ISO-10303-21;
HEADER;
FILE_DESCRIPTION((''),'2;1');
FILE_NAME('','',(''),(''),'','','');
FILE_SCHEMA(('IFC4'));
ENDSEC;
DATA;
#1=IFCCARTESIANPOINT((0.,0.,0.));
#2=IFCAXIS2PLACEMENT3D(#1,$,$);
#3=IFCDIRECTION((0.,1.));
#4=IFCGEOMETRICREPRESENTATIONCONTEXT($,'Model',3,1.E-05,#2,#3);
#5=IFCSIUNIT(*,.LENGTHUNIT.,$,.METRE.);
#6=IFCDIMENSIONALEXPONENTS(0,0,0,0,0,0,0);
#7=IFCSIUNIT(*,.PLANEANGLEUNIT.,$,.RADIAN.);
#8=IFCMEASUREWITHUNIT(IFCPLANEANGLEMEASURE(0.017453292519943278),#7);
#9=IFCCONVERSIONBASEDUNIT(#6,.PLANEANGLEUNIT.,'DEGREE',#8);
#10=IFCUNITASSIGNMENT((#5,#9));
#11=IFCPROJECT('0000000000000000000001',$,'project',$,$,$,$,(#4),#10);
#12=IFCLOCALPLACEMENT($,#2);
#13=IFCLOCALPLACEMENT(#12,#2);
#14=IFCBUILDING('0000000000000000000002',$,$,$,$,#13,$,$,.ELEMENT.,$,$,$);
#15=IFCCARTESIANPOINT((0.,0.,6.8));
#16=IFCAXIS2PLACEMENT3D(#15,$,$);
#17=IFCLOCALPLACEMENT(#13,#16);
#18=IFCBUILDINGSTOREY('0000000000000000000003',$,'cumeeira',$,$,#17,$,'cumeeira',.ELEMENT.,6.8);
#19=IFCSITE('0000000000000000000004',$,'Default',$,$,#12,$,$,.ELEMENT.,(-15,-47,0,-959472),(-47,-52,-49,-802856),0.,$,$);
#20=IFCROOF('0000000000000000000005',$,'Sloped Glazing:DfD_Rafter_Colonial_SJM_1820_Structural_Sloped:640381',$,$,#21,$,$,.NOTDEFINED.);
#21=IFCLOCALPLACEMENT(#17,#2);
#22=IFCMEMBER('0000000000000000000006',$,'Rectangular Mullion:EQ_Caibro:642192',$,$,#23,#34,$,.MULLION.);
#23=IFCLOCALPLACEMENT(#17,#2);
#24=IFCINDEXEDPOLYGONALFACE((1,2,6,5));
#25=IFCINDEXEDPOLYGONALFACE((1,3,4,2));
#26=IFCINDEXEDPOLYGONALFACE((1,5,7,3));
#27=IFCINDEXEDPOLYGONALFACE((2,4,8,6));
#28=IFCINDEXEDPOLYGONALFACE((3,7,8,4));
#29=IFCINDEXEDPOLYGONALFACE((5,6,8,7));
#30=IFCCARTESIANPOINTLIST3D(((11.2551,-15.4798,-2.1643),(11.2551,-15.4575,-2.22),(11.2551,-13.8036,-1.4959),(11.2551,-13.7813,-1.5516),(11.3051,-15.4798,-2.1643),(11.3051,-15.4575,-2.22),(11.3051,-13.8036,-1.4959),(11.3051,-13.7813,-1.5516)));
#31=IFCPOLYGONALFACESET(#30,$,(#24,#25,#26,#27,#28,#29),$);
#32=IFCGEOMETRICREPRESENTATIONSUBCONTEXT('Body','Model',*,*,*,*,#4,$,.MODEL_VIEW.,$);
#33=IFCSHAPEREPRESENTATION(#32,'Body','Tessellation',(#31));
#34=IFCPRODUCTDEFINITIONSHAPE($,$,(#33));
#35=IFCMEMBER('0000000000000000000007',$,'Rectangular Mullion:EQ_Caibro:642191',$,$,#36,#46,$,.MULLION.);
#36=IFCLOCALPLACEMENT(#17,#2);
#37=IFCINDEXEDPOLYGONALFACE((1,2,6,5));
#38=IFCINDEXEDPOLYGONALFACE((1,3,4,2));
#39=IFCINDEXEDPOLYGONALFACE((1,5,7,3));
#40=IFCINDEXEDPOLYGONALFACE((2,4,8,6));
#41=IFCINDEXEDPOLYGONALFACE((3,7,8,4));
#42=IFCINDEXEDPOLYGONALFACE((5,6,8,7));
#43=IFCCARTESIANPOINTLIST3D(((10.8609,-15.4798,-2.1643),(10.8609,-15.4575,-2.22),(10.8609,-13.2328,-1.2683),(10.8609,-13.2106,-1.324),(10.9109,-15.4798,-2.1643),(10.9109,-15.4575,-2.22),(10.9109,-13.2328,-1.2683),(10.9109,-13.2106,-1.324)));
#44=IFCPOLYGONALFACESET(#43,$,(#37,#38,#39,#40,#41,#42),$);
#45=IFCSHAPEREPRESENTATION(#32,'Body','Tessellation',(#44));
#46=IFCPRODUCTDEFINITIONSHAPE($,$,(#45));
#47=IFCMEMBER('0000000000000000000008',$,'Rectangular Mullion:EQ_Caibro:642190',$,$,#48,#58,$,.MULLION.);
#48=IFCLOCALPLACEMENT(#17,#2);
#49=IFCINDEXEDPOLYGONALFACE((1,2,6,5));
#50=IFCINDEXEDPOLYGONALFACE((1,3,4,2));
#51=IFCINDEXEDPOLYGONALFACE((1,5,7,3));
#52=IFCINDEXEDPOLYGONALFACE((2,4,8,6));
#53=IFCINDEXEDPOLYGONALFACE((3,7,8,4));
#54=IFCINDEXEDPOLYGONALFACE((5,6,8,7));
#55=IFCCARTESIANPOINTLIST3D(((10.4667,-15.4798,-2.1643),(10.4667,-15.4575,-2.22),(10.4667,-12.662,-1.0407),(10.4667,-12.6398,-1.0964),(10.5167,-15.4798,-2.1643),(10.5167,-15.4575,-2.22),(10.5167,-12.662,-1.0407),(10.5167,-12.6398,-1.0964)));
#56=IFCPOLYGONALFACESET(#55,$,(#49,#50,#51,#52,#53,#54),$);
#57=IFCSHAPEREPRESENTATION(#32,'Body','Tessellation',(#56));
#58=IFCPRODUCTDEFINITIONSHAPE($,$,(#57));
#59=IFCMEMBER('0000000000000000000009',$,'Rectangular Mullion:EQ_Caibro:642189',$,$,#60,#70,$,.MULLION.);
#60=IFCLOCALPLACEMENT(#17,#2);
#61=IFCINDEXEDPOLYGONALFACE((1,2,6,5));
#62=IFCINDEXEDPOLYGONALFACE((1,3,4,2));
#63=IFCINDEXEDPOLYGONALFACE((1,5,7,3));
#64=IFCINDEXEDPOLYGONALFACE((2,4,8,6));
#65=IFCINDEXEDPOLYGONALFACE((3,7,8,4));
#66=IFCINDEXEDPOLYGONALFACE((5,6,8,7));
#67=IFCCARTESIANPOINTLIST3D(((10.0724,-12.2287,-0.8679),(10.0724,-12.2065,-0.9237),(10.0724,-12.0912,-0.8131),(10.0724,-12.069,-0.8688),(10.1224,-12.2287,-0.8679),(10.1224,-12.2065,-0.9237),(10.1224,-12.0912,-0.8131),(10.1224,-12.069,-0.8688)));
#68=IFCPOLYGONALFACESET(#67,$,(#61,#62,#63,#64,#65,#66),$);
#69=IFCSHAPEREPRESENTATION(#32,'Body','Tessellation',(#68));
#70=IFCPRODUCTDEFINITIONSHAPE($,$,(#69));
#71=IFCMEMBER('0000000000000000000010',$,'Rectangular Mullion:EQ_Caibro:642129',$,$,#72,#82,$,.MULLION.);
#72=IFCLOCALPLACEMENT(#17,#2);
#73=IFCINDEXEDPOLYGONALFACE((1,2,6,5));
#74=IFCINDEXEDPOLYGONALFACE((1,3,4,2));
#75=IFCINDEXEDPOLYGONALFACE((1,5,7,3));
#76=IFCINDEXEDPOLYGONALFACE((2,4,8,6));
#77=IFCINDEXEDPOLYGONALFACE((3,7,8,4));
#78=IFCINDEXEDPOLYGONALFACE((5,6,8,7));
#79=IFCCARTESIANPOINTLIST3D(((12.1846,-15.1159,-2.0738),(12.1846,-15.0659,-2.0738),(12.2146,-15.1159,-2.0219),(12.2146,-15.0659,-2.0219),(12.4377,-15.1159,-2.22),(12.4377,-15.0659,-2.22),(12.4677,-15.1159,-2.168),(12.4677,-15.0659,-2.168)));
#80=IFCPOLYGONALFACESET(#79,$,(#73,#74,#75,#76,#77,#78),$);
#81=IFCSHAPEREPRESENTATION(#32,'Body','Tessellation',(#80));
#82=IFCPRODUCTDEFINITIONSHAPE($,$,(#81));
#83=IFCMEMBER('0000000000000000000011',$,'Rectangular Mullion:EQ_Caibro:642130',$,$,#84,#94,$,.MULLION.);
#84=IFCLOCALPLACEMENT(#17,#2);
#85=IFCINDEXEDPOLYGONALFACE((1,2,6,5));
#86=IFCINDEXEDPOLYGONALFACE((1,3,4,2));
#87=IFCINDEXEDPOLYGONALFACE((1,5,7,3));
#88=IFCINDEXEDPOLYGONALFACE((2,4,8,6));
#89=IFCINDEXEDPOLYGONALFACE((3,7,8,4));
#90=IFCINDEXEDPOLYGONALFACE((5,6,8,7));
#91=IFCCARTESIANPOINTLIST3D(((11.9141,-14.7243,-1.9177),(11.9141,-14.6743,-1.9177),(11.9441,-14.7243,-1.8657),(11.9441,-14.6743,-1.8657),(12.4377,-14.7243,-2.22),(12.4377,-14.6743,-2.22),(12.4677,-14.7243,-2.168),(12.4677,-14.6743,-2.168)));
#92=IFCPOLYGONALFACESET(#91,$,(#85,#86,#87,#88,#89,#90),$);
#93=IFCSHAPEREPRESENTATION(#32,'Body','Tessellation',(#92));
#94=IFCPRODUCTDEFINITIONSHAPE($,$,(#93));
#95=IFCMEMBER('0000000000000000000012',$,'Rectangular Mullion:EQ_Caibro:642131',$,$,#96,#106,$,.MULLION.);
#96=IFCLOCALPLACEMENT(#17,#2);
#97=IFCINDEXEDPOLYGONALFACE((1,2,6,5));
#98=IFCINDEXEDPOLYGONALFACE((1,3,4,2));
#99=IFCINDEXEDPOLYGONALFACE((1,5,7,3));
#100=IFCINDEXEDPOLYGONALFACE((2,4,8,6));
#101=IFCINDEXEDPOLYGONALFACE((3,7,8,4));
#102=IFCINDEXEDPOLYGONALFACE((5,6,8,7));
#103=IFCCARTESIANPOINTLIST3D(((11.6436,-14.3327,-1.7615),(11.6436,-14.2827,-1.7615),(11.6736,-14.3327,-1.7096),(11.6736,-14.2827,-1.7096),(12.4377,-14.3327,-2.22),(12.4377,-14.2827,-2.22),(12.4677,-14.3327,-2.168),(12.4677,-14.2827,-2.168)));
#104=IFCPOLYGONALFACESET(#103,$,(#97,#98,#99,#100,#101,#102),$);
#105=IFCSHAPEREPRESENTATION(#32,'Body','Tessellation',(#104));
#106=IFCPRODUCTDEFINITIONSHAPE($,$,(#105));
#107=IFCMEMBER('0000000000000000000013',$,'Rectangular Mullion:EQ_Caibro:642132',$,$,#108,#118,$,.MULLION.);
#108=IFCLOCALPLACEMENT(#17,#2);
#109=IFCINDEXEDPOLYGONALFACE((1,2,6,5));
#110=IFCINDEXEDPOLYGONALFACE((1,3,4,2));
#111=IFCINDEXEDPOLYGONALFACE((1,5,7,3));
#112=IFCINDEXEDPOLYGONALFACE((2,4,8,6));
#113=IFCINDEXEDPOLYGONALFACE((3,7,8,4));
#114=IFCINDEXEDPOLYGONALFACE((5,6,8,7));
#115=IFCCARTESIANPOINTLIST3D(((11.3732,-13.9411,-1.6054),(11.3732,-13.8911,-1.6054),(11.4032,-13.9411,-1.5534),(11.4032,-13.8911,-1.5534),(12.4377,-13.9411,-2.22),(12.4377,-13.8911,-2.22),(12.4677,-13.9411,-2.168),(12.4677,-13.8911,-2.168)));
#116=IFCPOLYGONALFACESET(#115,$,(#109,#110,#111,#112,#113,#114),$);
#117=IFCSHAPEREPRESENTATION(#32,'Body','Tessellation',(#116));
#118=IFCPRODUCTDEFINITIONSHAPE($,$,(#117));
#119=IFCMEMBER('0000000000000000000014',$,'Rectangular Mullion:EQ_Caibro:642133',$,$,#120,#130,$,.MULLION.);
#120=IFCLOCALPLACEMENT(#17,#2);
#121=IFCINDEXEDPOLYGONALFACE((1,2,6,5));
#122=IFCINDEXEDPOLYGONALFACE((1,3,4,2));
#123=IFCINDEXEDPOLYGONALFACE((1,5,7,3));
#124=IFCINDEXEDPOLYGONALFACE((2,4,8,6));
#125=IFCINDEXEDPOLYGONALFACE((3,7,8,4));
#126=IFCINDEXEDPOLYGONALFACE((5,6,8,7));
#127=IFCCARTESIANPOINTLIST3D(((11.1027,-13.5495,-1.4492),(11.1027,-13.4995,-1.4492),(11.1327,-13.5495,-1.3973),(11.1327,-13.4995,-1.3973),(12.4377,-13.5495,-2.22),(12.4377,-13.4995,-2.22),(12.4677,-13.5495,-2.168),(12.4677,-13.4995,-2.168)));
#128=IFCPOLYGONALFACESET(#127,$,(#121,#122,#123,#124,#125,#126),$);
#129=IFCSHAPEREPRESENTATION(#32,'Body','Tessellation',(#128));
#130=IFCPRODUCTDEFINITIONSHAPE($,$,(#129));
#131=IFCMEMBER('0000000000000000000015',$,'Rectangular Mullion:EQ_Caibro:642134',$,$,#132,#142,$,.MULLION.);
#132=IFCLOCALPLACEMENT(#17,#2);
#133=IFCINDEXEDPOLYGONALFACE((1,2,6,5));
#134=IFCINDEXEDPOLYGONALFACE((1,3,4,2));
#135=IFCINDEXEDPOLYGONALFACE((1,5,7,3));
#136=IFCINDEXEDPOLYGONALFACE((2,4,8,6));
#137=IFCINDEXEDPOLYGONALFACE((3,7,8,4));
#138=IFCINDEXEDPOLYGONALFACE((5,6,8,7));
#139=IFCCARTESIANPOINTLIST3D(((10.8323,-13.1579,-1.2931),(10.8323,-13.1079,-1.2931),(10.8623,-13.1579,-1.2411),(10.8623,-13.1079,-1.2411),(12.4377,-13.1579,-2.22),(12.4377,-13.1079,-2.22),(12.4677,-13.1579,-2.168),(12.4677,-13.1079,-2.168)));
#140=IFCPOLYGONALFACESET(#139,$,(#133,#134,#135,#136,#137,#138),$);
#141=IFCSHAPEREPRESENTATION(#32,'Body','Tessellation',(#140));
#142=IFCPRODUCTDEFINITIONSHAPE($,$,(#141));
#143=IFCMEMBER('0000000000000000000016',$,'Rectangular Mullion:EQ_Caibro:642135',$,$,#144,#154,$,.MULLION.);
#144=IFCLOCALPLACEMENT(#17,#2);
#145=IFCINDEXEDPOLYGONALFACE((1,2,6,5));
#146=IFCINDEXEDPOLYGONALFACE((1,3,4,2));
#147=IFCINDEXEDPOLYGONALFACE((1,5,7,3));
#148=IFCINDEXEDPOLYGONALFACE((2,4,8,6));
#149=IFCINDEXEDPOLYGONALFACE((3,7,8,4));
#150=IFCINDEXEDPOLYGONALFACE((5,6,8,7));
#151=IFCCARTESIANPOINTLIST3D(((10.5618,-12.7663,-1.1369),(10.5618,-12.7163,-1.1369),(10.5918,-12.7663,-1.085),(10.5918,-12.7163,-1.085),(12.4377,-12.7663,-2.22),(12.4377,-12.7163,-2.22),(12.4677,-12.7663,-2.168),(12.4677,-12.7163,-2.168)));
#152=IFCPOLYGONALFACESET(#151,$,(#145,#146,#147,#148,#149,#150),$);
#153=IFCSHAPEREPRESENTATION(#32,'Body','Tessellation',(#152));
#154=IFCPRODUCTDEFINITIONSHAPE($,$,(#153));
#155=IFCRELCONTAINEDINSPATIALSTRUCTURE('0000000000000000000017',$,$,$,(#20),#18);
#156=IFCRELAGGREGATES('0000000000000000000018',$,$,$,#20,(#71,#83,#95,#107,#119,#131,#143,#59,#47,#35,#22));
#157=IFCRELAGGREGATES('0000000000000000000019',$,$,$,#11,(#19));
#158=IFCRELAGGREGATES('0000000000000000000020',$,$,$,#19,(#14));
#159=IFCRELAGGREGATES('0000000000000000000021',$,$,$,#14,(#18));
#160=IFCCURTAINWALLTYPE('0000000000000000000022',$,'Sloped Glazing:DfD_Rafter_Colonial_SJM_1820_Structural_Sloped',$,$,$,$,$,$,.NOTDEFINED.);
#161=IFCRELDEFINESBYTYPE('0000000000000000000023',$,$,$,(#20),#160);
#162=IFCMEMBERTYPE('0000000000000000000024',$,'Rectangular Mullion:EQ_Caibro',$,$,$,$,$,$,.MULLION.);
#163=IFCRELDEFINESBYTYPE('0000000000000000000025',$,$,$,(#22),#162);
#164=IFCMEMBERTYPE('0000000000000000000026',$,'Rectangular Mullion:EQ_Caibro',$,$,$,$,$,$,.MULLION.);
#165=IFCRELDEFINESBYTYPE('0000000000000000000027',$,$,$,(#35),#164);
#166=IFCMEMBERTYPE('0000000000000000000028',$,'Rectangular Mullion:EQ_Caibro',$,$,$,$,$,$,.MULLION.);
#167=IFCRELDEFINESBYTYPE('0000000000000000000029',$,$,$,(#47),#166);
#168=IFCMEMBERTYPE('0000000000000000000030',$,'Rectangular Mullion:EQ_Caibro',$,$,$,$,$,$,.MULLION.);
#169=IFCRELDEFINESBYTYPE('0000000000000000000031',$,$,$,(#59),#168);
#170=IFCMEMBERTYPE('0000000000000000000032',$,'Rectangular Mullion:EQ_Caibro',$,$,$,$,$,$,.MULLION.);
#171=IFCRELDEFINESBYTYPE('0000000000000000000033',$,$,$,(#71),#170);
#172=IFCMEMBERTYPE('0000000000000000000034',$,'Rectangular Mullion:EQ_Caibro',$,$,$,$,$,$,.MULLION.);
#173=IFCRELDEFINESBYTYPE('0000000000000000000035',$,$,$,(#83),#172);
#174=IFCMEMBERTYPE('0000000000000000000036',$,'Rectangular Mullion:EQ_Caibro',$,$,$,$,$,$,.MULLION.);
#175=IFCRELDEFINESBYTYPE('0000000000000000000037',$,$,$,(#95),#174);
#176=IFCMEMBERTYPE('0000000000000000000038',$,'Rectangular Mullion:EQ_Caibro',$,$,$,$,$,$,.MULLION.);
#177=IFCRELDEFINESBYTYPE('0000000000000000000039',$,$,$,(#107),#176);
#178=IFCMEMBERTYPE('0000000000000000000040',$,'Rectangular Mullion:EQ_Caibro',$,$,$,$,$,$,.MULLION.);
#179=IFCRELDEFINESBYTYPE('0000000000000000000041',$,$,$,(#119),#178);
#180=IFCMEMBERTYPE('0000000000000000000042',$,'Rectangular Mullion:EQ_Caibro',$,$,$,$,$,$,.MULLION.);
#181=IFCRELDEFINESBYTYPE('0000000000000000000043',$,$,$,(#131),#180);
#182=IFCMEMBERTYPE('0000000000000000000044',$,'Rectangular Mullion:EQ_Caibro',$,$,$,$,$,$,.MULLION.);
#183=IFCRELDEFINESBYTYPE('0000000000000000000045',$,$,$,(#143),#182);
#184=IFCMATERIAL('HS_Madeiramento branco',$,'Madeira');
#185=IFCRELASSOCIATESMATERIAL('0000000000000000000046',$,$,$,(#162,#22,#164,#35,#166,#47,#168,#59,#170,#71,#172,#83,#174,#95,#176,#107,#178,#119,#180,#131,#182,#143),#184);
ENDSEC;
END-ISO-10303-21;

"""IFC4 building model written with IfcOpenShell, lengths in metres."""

from ifc_helpers import new_model, entity, si_unit, converted_unit, direction, frame, origin, place, context, subcontext, project, spatial, indexed_curve, outline, extrude, source, transform, mapped, material, type_object, type_shapes, element, aggregate, save


model = new_model("IFC4")

# Units and contexts
model_context = context("Model", 3, precision=1e-05, world=origin(), true_north=direction((0.0, 1.0)))
body_context = subcontext(model_context, "Body", "Model", "MODEL_VIEW")
ifc_project = project(units=[si_unit("LENGTHUNIT", "METRE"), converted_unit("PLANEANGLEUNIT", "DEGREE", entity("IfcPlaneAngleMeasure", 0.017453292519943278), si_unit("PLANEANGLEUNIT", "RADIAN"), dimensions=[0, 0, 0, 0, 0, 0, 0])], contexts=[model_context])

# Site, building, storey
site_placement = place(None, origin())
site = spatial("IfcSite", under=ifc_project, at=site_placement, Name="Default", CompositionType="ELEMENT", RefLatitude=(-15, -47, 0, -959472), RefLongitude=(-47, -52, -49, -802856), RefElevation=0.0)
building_placement = place(site_placement, origin())
building = spatial("IfcBuilding", under=site, at=building_placement, CompositionType="ELEMENT")
storey_placement = place(building_placement, frame((0.0, 0.0, 6.8)))
storey = spatial("IfcBuildingStorey", under=building, at=storey_placement, Name="cumeeira", LongName="cumeeira", CompositionType="ELEMENT", Elevation=6.8)

# Roof
curtain_wall_type_1 = type_object("IfcCurtainWallType", Name="Sloped Glazing:DfD_Rafter_Colonial_SJM_1820_Structural_Sloped", PredefinedType="NOTDEFINED")
roof_1_placement = place(storey_placement, frame((0.0, 0.0, -6.8)))
roof_1 = element("IfcRoof", 1, at=roof_1_placement, inside=storey, type_object=curtain_wall_type_1, Name="Sloped Glazing:DfD_Rafter_Colonial_SJM_1820_Structural_Sloped:640381", PredefinedType="NOTDEFINED")
ifc_material_1 = material(Name="HS_Madeiramento branco", Category="Madeira")

# Members
member_type_1 = type_object("IfcMemberType", Name="Rectangular Mullion:EQ_Caibro", PredefinedType="MULLION", material=ifc_material_1)
shared_shape_1 = source(origin(), body_context, "Body", "SweptSolid", [
    extrude(outline(indexed_curve([(-0.025, -0.03), (0.025, -0.03), (0.025, 0.03), (-0.025, 0.03), (-0.025, -0.03)], self_intersect=False)), frame((0.0, -0.03, -1.8045), z_axis=(0.0, 0.0, 1.0), x_axis=(-1.0, 0.0, 0.0)), (0.0, 0.0, 1.0), 1.8045),
])
type_shapes(member_type_1, [shared_shape_1])
member_1_placement = place(roof_1_placement, frame((11.2801, -13.7813, 5.2484), z_axis=(0.0, 0.928878, 0.370385), x_axis=(1.0, 0.0, 0.0)))
member_1 = element("IfcMember", 2, at=member_1_placement, type_object=member_type_1, material=ifc_material_1, Name="Rectangular Mullion:EQ_Caibro:642192", PredefinedType="MULLION", context=body_context, shape_type="MappedRepresentation", body=[
    mapped(shared_shape_1, transform((0.0, 0.0, 0.0), scale=1.0)),
])
member_type_2 = type_object("IfcMemberType", Name="Rectangular Mullion:EQ_Caibro", PredefinedType="MULLION", material=ifc_material_1)
shared_shape_2 = source(origin(), body_context, "Body", "SweptSolid", [
    extrude(outline(indexed_curve([(-0.025, -0.03), (0.025, -0.03), (0.025, 0.03), (-0.025, 0.03), (-0.025, -0.03)], self_intersect=False)), frame((0.0, -0.03, -2.419), z_axis=(0.0, 0.0, 1.0), x_axis=(-1.0, 0.0, 0.0)), (0.0, 0.0, 1.0), 2.419),
])
type_shapes(member_type_2, [shared_shape_2])
member_2_placement = place(roof_1_placement, frame((10.8859, -13.2106, 5.476), z_axis=(0.0, 0.928878, 0.370385), x_axis=(1.0, 0.0, 0.0)))
member_2 = element("IfcMember", 3, at=member_2_placement, type_object=member_type_2, material=ifc_material_1, Name="Rectangular Mullion:EQ_Caibro:642191", PredefinedType="MULLION", context=body_context, shape_type="MappedRepresentation", body=[
    mapped(shared_shape_2, transform((0.0, 0.0, 0.0), scale=1.0)),
])
member_type_3 = type_object("IfcMemberType", Name="Rectangular Mullion:EQ_Caibro", PredefinedType="MULLION", material=ifc_material_1)
shared_shape_3 = source(origin(), body_context, "Body", "SweptSolid", [
    extrude(outline(indexed_curve([(-0.025, -0.03), (0.025, -0.03), (0.025, 0.03), (-0.025, 0.03), (-0.025, -0.03)], self_intersect=False)), frame((0.0, -0.03, -3.0335), z_axis=(0.0, 0.0, 1.0), x_axis=(-1.0, 0.0, 0.0)), (0.0, 0.0, 1.0), 3.0335),
])
type_shapes(member_type_3, [shared_shape_3])
member_3_placement = place(roof_1_placement, frame((10.4917, -12.6398, 5.7036), z_axis=(0.0, 0.928878, 0.370385), x_axis=(1.0, 0.0, 0.0)))
member_3 = element("IfcMember", 4, at=member_3_placement, type_object=member_type_3, material=ifc_material_1, Name="Rectangular Mullion:EQ_Caibro:642190", PredefinedType="MULLION", context=body_context, shape_type="MappedRepresentation", body=[
    mapped(shared_shape_3, transform((0.0, 0.0, 0.0), scale=1.0)),
])
member_type_4 = type_object("IfcMemberType", Name="Rectangular Mullion:EQ_Caibro", PredefinedType="MULLION", material=ifc_material_1)
shared_shape_4 = source(origin(), body_context, "Body", "SweptSolid", [
    extrude(outline(indexed_curve([(-0.025, -0.03), (0.025, -0.03), (0.025, 0.03), (-0.025, 0.03), (-0.025, -0.03)], self_intersect=False)), frame((0.0, -0.03, -0.148), z_axis=(0.0, 0.0, 1.0), x_axis=(-1.0, 0.0, 0.0)), (0.0, 0.0, 1.0), 0.148),
])
type_shapes(member_type_4, [shared_shape_4])
member_4_placement = place(roof_1_placement, frame((10.0974, -12.069, 5.9312), z_axis=(0.0, 0.928878, 0.370385), x_axis=(1.0, 0.0, 0.0)))
member_4 = element("IfcMember", 5, at=member_4_placement, type_object=member_type_4, material=ifc_material_1, Name="Rectangular Mullion:EQ_Caibro:642189", PredefinedType="MULLION", context=body_context, shape_type="MappedRepresentation", body=[
    mapped(shared_shape_4, transform((0.0, 0.0, 0.0), scale=1.0)),
])
member_type_5 = type_object("IfcMemberType", Name="Rectangular Mullion:EQ_Caibro", PredefinedType="MULLION", material=ifc_material_1)
shared_shape_5 = source(origin(), body_context, "Body", "SweptSolid", [
    extrude(outline(indexed_curve([(-0.025, -0.03), (0.025, -0.03), (0.025, 0.03), (-0.025, 0.03), (-0.025, -0.03)], self_intersect=False)), frame((0.0, -0.03, -0.2924), z_axis=(0.0, 0.0, 1.0), x_axis=(-1.0, 0.0, 0.0)), (0.0, 0.0, 1.0), 0.2924),
])
type_shapes(member_type_5, [shared_shape_5])
member_5_placement = place(roof_1_placement, frame((12.1846, -15.0909, 4.7262), z_axis=(-0.866025, 0.0, 0.5), x_axis=(0.0, 1.0, 0.0)))
member_5 = element("IfcMember", 6, at=member_5_placement, type_object=member_type_5, material=ifc_material_1, Name="Rectangular Mullion:EQ_Caibro:642129", PredefinedType="MULLION", context=body_context, shape_type="MappedRepresentation", body=[
    mapped(shared_shape_5, transform((0.0, 0.0, 0.0), scale=1.0)),
])
member_type_6 = type_object("IfcMemberType", Name="Rectangular Mullion:EQ_Caibro", PredefinedType="MULLION", material=ifc_material_1)
shared_shape_6 = source(origin(), body_context, "Body", "SweptSolid", [
    extrude(outline(indexed_curve([(-0.025, -0.03), (0.025, -0.03), (0.025, 0.03), (-0.025, 0.03), (-0.025, -0.03)], self_intersect=False)), frame((0.0, -0.03, -0.6047), z_axis=(0.0, 0.0, 1.0), x_axis=(-1.0, 0.0, 0.0)), (0.0, 0.0, 1.0), 0.6047),
])
type_shapes(member_type_6, [shared_shape_6])
member_6_placement = place(roof_1_placement, frame((11.9141, -14.6993, 4.8823), z_axis=(-0.866025, 0.0, 0.5), x_axis=(0.0, 1.0, 0.0)))
member_6 = element("IfcMember", 7, at=member_6_placement, type_object=member_type_6, material=ifc_material_1, Name="Rectangular Mullion:EQ_Caibro:642130", PredefinedType="MULLION", context=body_context, shape_type="MappedRepresentation", body=[
    mapped(shared_shape_6, transform((0.0, 0.0, 0.0), scale=1.0)),
])
member_type_7 = type_object("IfcMemberType", Name="Rectangular Mullion:EQ_Caibro", PredefinedType="MULLION", material=ifc_material_1)
shared_shape_7 = source(origin(), body_context, "Body", "SweptSolid", [
    extrude(outline(indexed_curve([(-0.025, -0.03), (0.025, -0.03), (0.025, 0.03), (-0.025, 0.03), (-0.025, -0.03)], self_intersect=False)), frame((0.0, -0.03, -0.917), z_axis=(0.0, 0.0, 1.0), x_axis=(-1.0, 0.0, 0.0)), (0.0, 0.0, 1.0), 0.917),
])
type_shapes(member_type_7, [shared_shape_7])
member_7_placement = place(roof_1_placement, frame((11.6436, -14.3077, 5.0385), z_axis=(-0.866025, 0.0, 0.5), x_axis=(0.0, 1.0, 0.0)))
member_7 = element("IfcMember", 8, at=member_7_placement, type_object=member_type_7, material=ifc_material_1, Name="Rectangular Mullion:EQ_Caibro:642131", PredefinedType="MULLION", context=body_context, shape_type="MappedRepresentation", body=[
    mapped(shared_shape_7, transform((0.0, 0.0, 0.0), scale=1.0)),
])
member_type_8 = type_object("IfcMemberType", Name="Rectangular Mullion:EQ_Caibro", PredefinedType="MULLION", material=ifc_material_1)
shared_shape_8 = source(origin(), body_context, "Body", "SweptSolid", [
    extrude(outline(indexed_curve([(-0.025, -0.03), (0.025, -0.03), (0.025, 0.03), (-0.025, 0.03), (-0.025, -0.03)], self_intersect=False)), frame((0.0, -0.03, -1.2293), z_axis=(0.0, 0.0, 1.0), x_axis=(-1.0, 0.0, 0.0)), (0.0, 0.0, 1.0), 1.2293),
])
type_shapes(member_type_8, [shared_shape_8])
member_8_placement = place(roof_1_placement, frame((11.3732, -13.9161, 5.1946), z_axis=(-0.866025, 0.0, 0.5), x_axis=(0.0, 1.0, 0.0)))
member_8 = element("IfcMember", 9, at=member_8_placement, type_object=member_type_8, material=ifc_material_1, Name="Rectangular Mullion:EQ_Caibro:642132", PredefinedType="MULLION", context=body_context, shape_type="MappedRepresentation", body=[
    mapped(shared_shape_8, transform((0.0, 0.0, 0.0), scale=1.0)),
])
member_type_9 = type_object("IfcMemberType", Name="Rectangular Mullion:EQ_Caibro", PredefinedType="MULLION", material=ifc_material_1)
shared_shape_9 = source(origin(), body_context, "Body", "SweptSolid", [
    extrude(outline(indexed_curve([(-0.025, -0.03), (0.025, -0.03), (0.025, 0.03), (-0.025, 0.03), (-0.025, -0.03)], self_intersect=False)), frame((0.0, -0.03, -1.5415), z_axis=(0.0, 0.0, 1.0), x_axis=(-1.0, 0.0, 0.0)), (0.0, 0.0, 1.0), 1.5415),
])
type_shapes(member_type_9, [shared_shape_9])
member_9_placement = place(roof_1_placement, frame((11.1027, -13.5245, 5.3508), z_axis=(-0.866025, 0.0, 0.5), x_axis=(0.0, 1.0, 0.0)))
member_9 = element("IfcMember", 10, at=member_9_placement, type_object=member_type_9, material=ifc_material_1, Name="Rectangular Mullion:EQ_Caibro:642133", PredefinedType="MULLION", context=body_context, shape_type="MappedRepresentation", body=[
    mapped(shared_shape_9, transform((0.0, 0.0, 0.0), scale=1.0)),
])
member_type_10 = type_object("IfcMemberType", Name="Rectangular Mullion:EQ_Caibro", PredefinedType="MULLION", material=ifc_material_1)
shared_shape_10 = source(origin(), body_context, "Body", "SweptSolid", [
    extrude(outline(indexed_curve([(-0.025, -0.03), (0.025, -0.03), (0.025, 0.03), (-0.025, 0.03), (-0.025, -0.03)], self_intersect=False)), frame((0.0, -0.03, -1.8538), z_axis=(0.0, 0.0, 1.0), x_axis=(-1.0, 0.0, 0.0)), (0.0, 0.0, 1.0), 1.8538),
])
type_shapes(member_type_10, [shared_shape_10])
member_10_placement = place(roof_1_placement, frame((10.8323, -13.1329, 5.5069), z_axis=(-0.866025, 0.0, 0.5), x_axis=(0.0, 1.0, 0.0)))
member_10 = element("IfcMember", 11, at=member_10_placement, type_object=member_type_10, material=ifc_material_1, Name="Rectangular Mullion:EQ_Caibro:642134", PredefinedType="MULLION", context=body_context, shape_type="MappedRepresentation", body=[
    mapped(shared_shape_10, transform((0.0, 0.0, 0.0), scale=1.0)),
])
member_type_11 = type_object("IfcMemberType", Name="Rectangular Mullion:EQ_Caibro", PredefinedType="MULLION", material=ifc_material_1)
shared_shape_11 = source(origin(), body_context, "Body", "SweptSolid", [
    extrude(outline(indexed_curve([(-0.025, -0.03), (0.025, -0.03), (0.025, 0.03), (-0.025, 0.03), (-0.025, -0.03)], self_intersect=False)), frame((0.0, -0.03, -2.1661), z_axis=(0.0, 0.0, 1.0), x_axis=(-1.0, 0.0, 0.0)), (0.0, 0.0, 1.0), 2.1661),
])
type_shapes(member_type_11, [shared_shape_11])
member_11_placement = place(roof_1_placement, frame((10.5618, -12.7413, 5.6631), z_axis=(-0.866025, 0.0, 0.5), x_axis=(0.0, 1.0, 0.0)))
member_11 = element("IfcMember", 12, at=member_11_placement, type_object=member_type_11, material=ifc_material_1, Name="Rectangular Mullion:EQ_Caibro:642135", PredefinedType="MULLION", context=body_context, shape_type="MappedRepresentation", body=[
    mapped(shared_shape_11, transform((0.0, 0.0, 0.0), scale=1.0)),
])
aggregate(roof_1, [member_5, member_6, member_7, member_8, member_9, member_10, member_11, member_4, member_3, member_2, member_1])

save(model, "model.ifc")
